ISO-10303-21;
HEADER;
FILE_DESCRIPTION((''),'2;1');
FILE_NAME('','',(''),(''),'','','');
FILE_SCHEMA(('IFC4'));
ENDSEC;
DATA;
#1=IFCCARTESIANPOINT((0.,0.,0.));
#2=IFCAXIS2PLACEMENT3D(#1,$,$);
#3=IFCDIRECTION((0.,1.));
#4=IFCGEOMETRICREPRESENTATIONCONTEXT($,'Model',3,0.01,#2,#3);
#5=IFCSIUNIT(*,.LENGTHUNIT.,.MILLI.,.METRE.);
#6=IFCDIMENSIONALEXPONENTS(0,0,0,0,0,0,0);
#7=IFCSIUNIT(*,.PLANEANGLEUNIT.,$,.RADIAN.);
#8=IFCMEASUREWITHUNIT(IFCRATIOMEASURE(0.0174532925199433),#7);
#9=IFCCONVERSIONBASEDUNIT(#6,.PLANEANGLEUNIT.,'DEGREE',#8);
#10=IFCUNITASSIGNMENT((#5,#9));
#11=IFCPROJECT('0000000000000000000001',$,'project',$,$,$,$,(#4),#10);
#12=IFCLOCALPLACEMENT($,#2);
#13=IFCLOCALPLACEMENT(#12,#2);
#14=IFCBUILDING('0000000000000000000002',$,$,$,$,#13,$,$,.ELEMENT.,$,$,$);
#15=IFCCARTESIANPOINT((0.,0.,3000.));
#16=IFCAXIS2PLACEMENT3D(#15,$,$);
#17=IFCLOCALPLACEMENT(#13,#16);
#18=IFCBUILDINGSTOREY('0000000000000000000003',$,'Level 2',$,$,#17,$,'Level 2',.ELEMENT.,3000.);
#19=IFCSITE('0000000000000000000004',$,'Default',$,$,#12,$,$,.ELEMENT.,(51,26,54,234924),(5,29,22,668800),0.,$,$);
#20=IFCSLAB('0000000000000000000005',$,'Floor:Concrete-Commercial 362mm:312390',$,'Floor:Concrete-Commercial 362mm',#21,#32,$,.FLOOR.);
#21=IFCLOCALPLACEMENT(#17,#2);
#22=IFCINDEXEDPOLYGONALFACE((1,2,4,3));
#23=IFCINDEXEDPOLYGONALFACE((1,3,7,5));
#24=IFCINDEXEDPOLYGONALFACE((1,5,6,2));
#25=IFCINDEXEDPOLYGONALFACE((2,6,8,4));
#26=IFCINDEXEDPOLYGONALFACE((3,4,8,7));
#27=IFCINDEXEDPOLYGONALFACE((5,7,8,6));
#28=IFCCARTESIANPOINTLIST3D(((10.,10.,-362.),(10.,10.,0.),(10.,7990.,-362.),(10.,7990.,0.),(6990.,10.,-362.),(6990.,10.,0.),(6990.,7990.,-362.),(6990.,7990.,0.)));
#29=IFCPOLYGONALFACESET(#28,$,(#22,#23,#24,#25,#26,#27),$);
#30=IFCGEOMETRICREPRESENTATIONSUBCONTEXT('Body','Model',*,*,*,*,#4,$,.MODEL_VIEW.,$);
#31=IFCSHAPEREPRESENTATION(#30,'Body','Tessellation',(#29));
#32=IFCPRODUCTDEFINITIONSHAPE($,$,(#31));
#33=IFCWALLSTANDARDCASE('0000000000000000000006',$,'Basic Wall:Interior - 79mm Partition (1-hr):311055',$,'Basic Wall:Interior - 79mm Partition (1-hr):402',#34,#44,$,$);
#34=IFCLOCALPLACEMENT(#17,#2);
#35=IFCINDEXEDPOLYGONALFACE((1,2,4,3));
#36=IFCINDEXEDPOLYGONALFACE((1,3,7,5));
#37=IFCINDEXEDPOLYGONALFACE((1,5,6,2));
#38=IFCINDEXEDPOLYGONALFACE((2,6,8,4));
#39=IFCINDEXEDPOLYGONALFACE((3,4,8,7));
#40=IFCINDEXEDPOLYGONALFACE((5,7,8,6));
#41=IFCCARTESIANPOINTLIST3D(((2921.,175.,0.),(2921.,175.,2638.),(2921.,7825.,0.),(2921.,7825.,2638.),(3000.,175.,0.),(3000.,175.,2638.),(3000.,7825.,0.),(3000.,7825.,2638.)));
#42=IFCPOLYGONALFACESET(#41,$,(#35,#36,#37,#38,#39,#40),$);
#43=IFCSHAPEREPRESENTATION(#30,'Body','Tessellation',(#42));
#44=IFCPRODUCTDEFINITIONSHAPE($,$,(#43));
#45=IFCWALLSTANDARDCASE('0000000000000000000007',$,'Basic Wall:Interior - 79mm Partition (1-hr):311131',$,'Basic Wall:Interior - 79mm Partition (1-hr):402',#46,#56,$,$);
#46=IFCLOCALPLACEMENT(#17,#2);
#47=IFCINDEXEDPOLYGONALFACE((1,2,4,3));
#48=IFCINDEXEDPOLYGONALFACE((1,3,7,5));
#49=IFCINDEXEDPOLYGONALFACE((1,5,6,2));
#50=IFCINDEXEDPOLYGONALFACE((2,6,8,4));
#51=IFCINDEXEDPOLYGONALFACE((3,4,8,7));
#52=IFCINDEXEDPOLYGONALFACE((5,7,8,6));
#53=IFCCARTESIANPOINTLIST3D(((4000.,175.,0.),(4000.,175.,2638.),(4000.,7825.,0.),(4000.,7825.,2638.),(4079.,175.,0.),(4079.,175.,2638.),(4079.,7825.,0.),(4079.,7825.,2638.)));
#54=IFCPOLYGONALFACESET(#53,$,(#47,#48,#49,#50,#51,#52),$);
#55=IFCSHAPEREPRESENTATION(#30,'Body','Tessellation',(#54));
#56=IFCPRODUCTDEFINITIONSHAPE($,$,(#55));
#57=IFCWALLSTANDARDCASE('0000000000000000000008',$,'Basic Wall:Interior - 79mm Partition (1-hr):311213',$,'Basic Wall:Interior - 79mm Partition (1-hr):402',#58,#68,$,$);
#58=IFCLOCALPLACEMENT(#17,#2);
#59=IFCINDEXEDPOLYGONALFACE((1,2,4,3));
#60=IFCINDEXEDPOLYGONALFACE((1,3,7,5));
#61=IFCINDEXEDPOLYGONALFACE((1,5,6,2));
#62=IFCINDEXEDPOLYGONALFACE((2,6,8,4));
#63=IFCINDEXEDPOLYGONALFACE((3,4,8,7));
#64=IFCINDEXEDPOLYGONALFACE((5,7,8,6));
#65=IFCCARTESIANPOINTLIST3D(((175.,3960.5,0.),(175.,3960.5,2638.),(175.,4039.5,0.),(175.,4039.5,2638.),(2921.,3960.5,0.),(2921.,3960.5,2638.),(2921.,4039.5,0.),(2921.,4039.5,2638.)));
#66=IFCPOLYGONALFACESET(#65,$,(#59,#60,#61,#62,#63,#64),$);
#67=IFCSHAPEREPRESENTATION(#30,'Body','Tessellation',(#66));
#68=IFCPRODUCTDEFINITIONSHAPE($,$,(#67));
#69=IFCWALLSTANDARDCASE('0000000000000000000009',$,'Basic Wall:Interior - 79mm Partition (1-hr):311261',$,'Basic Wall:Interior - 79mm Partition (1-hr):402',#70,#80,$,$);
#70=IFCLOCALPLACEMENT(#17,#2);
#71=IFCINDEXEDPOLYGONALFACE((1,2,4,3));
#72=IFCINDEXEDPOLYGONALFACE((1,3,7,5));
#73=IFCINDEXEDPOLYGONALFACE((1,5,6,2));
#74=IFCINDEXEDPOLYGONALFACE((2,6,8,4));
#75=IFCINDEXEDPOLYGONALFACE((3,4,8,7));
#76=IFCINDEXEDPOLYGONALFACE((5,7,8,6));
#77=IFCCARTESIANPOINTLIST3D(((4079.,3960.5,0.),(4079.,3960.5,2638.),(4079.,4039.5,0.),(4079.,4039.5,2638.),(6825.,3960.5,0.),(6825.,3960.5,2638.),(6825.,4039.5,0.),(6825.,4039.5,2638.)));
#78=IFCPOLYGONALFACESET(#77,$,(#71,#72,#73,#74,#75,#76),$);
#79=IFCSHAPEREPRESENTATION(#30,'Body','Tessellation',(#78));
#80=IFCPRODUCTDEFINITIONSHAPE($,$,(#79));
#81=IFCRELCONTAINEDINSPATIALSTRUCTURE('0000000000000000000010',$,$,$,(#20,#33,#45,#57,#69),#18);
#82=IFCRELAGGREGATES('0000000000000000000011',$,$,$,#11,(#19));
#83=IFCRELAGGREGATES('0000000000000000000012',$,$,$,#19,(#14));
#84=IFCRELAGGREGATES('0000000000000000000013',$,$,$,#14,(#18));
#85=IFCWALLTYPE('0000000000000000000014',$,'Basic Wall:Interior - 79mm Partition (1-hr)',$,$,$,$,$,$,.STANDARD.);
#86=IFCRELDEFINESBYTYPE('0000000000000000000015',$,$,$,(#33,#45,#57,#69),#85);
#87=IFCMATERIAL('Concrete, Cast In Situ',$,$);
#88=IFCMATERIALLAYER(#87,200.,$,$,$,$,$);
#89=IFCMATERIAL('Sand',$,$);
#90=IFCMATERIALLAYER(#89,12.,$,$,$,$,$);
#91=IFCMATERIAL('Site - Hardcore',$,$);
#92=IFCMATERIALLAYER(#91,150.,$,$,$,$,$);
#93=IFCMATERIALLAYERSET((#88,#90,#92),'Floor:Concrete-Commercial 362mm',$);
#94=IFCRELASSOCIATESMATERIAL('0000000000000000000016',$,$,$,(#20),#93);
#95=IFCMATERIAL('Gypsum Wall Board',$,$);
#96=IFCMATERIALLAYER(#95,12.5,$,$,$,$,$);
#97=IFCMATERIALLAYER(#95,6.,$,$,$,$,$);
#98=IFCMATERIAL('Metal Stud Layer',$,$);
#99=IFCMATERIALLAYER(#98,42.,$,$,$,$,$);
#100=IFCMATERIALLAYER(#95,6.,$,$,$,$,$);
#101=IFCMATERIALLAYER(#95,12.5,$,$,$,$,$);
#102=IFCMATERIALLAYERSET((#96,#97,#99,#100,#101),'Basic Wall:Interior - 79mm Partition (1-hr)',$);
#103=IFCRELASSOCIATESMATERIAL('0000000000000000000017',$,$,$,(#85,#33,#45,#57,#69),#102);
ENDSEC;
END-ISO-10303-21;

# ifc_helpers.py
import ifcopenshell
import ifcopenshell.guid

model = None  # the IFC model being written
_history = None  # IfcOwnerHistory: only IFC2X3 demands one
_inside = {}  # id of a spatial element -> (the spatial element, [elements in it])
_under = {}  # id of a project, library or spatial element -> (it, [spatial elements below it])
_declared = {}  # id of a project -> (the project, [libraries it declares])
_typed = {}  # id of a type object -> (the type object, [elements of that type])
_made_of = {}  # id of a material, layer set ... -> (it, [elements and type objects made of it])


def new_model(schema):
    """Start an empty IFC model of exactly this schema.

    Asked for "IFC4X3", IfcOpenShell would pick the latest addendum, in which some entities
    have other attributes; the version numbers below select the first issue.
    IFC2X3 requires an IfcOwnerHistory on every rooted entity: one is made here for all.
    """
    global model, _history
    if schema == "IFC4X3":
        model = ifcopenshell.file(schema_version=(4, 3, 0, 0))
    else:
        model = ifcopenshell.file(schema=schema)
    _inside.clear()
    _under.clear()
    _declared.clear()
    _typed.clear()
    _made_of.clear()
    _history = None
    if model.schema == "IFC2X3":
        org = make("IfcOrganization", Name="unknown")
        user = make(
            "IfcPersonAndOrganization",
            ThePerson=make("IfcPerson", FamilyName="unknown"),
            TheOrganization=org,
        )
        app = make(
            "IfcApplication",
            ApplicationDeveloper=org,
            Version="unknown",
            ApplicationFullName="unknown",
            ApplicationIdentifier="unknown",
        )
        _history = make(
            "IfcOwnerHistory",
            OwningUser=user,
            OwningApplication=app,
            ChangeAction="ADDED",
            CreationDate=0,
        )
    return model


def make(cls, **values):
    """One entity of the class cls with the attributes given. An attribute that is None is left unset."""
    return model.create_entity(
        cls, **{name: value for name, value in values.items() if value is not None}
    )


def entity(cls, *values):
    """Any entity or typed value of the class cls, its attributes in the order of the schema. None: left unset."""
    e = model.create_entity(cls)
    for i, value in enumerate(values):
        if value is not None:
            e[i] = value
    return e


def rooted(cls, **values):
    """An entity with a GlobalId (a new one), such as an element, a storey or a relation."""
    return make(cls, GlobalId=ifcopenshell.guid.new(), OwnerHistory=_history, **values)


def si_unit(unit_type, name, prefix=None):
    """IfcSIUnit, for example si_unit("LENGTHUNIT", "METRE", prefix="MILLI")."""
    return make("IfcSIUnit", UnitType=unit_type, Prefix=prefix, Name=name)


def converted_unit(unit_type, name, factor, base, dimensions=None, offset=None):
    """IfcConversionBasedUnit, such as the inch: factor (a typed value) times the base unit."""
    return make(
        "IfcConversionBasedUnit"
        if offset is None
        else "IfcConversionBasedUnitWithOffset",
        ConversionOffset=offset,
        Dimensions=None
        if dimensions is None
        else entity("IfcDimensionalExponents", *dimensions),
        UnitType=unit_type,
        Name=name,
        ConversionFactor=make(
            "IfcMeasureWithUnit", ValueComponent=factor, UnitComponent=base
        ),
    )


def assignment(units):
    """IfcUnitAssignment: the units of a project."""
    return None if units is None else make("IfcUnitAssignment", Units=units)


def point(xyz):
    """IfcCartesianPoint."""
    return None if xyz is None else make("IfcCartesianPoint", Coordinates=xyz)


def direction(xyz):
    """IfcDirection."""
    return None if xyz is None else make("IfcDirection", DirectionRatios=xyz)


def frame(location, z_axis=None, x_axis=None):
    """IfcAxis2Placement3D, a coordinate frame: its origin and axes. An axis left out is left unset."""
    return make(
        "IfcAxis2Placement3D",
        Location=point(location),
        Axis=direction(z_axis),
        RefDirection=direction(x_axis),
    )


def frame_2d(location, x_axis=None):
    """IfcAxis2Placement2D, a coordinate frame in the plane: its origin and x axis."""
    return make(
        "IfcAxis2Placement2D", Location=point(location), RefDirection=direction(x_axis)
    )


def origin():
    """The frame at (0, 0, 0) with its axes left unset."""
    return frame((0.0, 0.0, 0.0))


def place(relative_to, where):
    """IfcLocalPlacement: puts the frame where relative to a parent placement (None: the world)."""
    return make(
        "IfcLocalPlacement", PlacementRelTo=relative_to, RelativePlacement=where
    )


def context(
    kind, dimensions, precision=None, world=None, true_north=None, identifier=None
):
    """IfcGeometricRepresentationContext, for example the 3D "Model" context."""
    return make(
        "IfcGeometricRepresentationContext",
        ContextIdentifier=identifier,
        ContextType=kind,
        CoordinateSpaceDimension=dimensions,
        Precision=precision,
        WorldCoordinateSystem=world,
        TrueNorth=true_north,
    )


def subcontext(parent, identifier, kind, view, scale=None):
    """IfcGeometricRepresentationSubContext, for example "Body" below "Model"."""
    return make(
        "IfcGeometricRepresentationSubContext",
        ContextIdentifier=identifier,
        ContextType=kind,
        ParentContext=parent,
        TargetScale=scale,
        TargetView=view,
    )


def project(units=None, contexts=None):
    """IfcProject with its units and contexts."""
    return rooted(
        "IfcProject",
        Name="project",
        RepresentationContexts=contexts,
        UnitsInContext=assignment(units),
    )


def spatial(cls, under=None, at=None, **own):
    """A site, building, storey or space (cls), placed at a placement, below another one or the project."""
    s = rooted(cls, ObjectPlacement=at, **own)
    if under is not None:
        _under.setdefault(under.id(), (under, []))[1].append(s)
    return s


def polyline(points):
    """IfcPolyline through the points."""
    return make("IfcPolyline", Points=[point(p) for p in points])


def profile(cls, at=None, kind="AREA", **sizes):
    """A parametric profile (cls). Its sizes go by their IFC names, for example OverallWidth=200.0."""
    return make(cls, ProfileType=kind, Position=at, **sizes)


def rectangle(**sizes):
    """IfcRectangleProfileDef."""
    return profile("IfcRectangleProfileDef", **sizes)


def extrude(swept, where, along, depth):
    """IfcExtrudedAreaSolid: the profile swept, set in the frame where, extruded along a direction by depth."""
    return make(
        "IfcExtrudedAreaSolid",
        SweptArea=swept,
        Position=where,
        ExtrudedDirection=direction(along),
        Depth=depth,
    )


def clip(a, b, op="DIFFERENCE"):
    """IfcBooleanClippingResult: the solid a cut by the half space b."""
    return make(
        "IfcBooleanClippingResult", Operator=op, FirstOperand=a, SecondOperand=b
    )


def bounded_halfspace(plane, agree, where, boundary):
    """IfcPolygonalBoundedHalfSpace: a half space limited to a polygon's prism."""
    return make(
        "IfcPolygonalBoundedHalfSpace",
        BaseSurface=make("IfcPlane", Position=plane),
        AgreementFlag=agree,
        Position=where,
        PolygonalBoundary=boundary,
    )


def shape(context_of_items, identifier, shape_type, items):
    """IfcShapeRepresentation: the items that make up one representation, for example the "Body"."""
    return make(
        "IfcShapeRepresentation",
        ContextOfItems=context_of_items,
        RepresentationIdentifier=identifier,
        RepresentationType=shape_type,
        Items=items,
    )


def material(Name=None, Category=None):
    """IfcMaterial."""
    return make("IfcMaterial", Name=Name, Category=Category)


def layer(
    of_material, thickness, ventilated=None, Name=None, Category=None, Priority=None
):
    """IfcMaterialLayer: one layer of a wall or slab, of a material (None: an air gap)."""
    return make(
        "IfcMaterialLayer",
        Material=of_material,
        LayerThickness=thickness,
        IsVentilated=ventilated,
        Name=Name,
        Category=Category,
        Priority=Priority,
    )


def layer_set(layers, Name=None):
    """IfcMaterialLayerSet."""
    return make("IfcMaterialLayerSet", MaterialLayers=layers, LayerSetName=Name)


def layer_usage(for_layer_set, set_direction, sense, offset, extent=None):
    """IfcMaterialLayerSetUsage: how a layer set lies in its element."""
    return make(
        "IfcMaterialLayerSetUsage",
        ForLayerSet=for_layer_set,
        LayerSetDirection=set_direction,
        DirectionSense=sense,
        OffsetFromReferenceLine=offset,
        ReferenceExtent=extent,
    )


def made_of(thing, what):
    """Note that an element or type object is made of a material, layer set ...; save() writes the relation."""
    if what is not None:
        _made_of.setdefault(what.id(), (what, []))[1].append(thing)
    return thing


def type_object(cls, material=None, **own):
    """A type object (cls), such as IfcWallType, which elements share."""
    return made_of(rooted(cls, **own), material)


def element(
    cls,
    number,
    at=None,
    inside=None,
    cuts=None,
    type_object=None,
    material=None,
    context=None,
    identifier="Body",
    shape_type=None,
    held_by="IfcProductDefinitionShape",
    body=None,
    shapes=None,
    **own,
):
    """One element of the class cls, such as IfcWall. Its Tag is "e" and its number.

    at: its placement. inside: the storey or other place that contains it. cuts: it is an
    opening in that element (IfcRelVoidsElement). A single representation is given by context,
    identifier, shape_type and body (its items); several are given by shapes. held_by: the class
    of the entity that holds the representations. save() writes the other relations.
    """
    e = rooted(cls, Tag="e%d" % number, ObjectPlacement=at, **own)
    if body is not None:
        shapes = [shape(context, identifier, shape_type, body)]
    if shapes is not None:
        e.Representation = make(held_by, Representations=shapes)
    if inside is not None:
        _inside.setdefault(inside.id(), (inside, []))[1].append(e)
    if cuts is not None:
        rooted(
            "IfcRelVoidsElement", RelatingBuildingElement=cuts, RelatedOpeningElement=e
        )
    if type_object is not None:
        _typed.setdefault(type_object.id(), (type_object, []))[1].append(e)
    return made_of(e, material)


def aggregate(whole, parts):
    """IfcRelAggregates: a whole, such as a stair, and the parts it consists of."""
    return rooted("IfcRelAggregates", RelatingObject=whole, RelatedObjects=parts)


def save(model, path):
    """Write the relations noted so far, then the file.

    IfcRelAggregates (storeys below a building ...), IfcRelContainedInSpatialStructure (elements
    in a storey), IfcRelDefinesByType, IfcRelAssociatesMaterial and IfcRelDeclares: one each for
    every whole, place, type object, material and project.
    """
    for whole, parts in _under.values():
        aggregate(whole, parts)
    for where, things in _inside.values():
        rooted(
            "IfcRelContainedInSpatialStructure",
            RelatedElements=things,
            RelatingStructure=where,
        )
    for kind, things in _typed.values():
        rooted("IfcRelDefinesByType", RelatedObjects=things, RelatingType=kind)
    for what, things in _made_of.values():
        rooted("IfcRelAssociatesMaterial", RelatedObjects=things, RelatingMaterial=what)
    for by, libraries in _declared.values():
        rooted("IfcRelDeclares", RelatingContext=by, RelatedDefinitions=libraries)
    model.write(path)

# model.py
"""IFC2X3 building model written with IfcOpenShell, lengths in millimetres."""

from ifc_helpers import new_model, entity, si_unit, converted_unit, direction, frame, frame_2d, origin, place, context, subcontext, project, spatial, polyline, rectangle, extrude, clip, bounded_halfspace, material, layer, layer_set, layer_usage, type_object, element, save


model = new_model("IFC2X3")

# Units and contexts
model_context = context("Model", 3, precision=0.01, world=origin(), true_north=direction((0.0, 1.0)))
body_context = subcontext(model_context, "Body", "Model", "MODEL_VIEW")
ifc_project = project(units=[si_unit("LENGTHUNIT", "METRE", prefix="MILLI"), converted_unit("PLANEANGLEUNIT", "DEGREE", entity("IfcRatioMeasure", 0.0174532925199433), si_unit("PLANEANGLEUNIT", "RADIAN"), dimensions=[0, 0, 0, 0, 0, 0, 0])], contexts=[model_context])

# Site, building, storey
site_placement = place(None, origin())
site = spatial("IfcSite", under=ifc_project, at=site_placement, Name="Default", CompositionType="ELEMENT", RefLatitude=(51, 26, 54, 234924), RefLongitude=(5, 29, 22, 668800), RefElevation=0.0)
building_placement = place(site_placement, origin())
building = spatial("IfcBuilding", under=site, at=building_placement, CompositionType="ELEMENT")
storey_placement = place(building_placement, frame((0.0, 0.0, 3000.0)))
storey = spatial("IfcBuildingStorey", under=building, at=storey_placement, Name="Level 2", LongName="Level 2", CompositionType="ELEMENT", Elevation=3000.0)

# Slab
ifc_material_1 = material(Name="Concrete, Cast In Situ")
ifc_layer_1 = layer(ifc_material_1, 200.0)
ifc_material_2 = material(Name="Sand")
ifc_layer_2 = layer(ifc_material_2, 12.0)
ifc_material_3 = material(Name="Site - Hardcore")
ifc_layer_3 = layer(ifc_material_3, 150.0)
ifc_layer_set_1 = layer_set([ifc_layer_1, ifc_layer_2, ifc_layer_3], Name="Floor:Concrete-Commercial 362mm")
ifc_layer_usage_1 = layer_usage(ifc_layer_set_1, "AXIS3", "POSITIVE", 0.0)
slab_placement = place(storey_placement, origin())
element("IfcSlab", 1, at=slab_placement, inside=storey, material=ifc_layer_usage_1, Name="Floor:Concrete-Commercial 362mm:312390", ObjectType="Floor:Concrete-Commercial 362mm", PredefinedType="FLOOR", context=body_context, shape_type="SweptSolid", body=[
    extrude(rectangle(XDim=7980.0, YDim=6980.0, at=frame_2d((0.0, 0.0), x_axis=(1.0, 0.0))), frame((3500.0, 4000.0, 0.0), z_axis=(0.0, 0.0, -1.0), x_axis=(0.0, 1.0, 0.0)), (0.0, 0.0, 1.0), 362.0),
])

# Walls
ifc_material_4 = material(Name="Gypsum Wall Board")
ifc_layer_4 = layer(ifc_material_4, 12.5)
ifc_layer_5 = layer(ifc_material_4, 6.0)
ifc_material_5 = material(Name="Metal Stud Layer")
ifc_layer_6 = layer(ifc_material_5, 42.0)
ifc_layer_7 = layer(ifc_material_4, 6.0)
ifc_layer_8 = layer(ifc_material_4, 12.5)
ifc_layer_set_2 = layer_set([ifc_layer_4, ifc_layer_5, ifc_layer_6, ifc_layer_7, ifc_layer_8], Name="Basic Wall:Interior - 79mm Partition (1-hr)")
ifc_layer_usage_2 = layer_usage(ifc_layer_set_2, "AXIS2", "NEGATIVE", 39.5)
wall_type = type_object("IfcWallType", Name="Basic Wall:Interior - 79mm Partition (1-hr)", PredefinedType="STANDARD", material=ifc_layer_set_2)
wall_1_placement = place(storey_placement, frame((2960.5, 7825.0, 0.0), z_axis=(0.0, 0.0, 1.0), x_axis=(0.0, -1.0, 0.0)))
element("IfcWallStandardCase", 2, at=wall_1_placement, inside=storey, type_object=wall_type, material=ifc_layer_usage_2, Name="Basic Wall:Interior - 79mm Partition (1-hr):311055", ObjectType="Basic Wall:Interior - 79mm Partition (1-hr):402", context=body_context, shape_type="Clipping", body=[
    clip(extrude(rectangle(XDim=7650.0, YDim=79.0, at=frame_2d((3825.0, 0.0), x_axis=(-1.0, 0.0))), origin(), (0.0, 0.0, 1.0), 2638.0), bounded_halfspace(frame((0.0, -39.5, 2638.0), z_axis=(0.0, 0.0, -1.0), x_axis=(1.0, 0.0, 0.0)), True, frame((0.0, -39.5, 2638.0)), polyline([(0.0, 0.0), (3785.5, 0.0), (3864.5, 0.0), (7650.0, 0.0), (7650.0, 79.0), (0.0, 79.0), (0.0, 0.0)]))),
])
ifc_layer_usage_3 = layer_usage(ifc_layer_set_2, "AXIS2", "NEGATIVE", 39.5)
wall_2_placement = place(storey_placement, frame((4039.5, 175.0, 0.0), z_axis=(0.0, 0.0, 1.0), x_axis=(0.0, 1.0, 0.0)))
element("IfcWallStandardCase", 3, at=wall_2_placement, inside=storey, type_object=wall_type, material=ifc_layer_usage_3, Name="Basic Wall:Interior - 79mm Partition (1-hr):311131", ObjectType="Basic Wall:Interior - 79mm Partition (1-hr):402", context=body_context, shape_type="Clipping", body=[
    clip(extrude(rectangle(XDim=7650.0, YDim=79.0, at=frame_2d((3825.0, 0.0), x_axis=(-1.0, 0.0))), origin(), (0.0, 0.0, 1.0), 2638.0), bounded_halfspace(frame((0.0, -39.5, 2638.0), z_axis=(0.0, 0.0, -1.0), x_axis=(-1.0, 0.0, 0.0)), True, frame((0.0, -39.5, 2638.0)), polyline([(0.0, 0.0), (3785.5, 0.0), (3864.5, 0.0), (7650.0, 0.0), (7650.0, 79.0), (0.0, 79.0), (0.0, 0.0)]))),
])
ifc_layer_usage_4 = layer_usage(ifc_layer_set_2, "AXIS2", "NEGATIVE", 39.5)
wall_3_placement = place(storey_placement, frame((175.0, 4000.0, 0.0)))
element("IfcWallStandardCase", 4, at=wall_3_placement, inside=storey, type_object=wall_type, material=ifc_layer_usage_4, Name="Basic Wall:Interior - 79mm Partition (1-hr):311213", ObjectType="Basic Wall:Interior - 79mm Partition (1-hr):402", context=body_context, shape_type="Clipping", body=[
    clip(extrude(rectangle(XDim=2746.0, YDim=79.0, at=frame_2d((1373.0, 0.0), x_axis=(-1.0, 0.0))), origin(), (0.0, 0.0, 1.0), 2638.0), bounded_halfspace(frame((0.0, -39.5, 2638.0), z_axis=(0.0, 0.0, -1.0), x_axis=(0.0, -1.0, 0.0)), True, frame((0.0, -39.5, 2638.0)), polyline([(0.0, 0.0), (2746.0, 0.0), (2746.0, 79.0), (0.0, 79.0), (0.0, 0.0)]))),
])
ifc_layer_usage_5 = layer_usage(ifc_layer_set_2, "AXIS2", "NEGATIVE", 39.5)
wall_4_placement = place(storey_placement, frame((4079.0, 4000.0, 0.0)))
element("IfcWallStandardCase", 5, at=wall_4_placement, inside=storey, type_object=wall_type, material=ifc_layer_usage_5, Name="Basic Wall:Interior - 79mm Partition (1-hr):311261", ObjectType="Basic Wall:Interior - 79mm Partition (1-hr):402", context=body_context, shape_type="Clipping", body=[
    clip(extrude(rectangle(XDim=2746.0, YDim=79.0, at=frame_2d((1373.0, 0.0), x_axis=(-1.0, 0.0))), origin(), (0.0, 0.0, 1.0), 2638.0), bounded_halfspace(frame((0.0, -39.5, 2638.0), z_axis=(0.0, 0.0, -1.0), x_axis=(0.0, -1.0, 0.0)), True, frame((0.0, -39.5, 2638.0)), polyline([(0.0, 0.0), (2746.0, 0.0), (2746.0, 79.0), (0.0, 79.0), (0.0, 0.0)]))),
])

save(model, "model.ifc")
